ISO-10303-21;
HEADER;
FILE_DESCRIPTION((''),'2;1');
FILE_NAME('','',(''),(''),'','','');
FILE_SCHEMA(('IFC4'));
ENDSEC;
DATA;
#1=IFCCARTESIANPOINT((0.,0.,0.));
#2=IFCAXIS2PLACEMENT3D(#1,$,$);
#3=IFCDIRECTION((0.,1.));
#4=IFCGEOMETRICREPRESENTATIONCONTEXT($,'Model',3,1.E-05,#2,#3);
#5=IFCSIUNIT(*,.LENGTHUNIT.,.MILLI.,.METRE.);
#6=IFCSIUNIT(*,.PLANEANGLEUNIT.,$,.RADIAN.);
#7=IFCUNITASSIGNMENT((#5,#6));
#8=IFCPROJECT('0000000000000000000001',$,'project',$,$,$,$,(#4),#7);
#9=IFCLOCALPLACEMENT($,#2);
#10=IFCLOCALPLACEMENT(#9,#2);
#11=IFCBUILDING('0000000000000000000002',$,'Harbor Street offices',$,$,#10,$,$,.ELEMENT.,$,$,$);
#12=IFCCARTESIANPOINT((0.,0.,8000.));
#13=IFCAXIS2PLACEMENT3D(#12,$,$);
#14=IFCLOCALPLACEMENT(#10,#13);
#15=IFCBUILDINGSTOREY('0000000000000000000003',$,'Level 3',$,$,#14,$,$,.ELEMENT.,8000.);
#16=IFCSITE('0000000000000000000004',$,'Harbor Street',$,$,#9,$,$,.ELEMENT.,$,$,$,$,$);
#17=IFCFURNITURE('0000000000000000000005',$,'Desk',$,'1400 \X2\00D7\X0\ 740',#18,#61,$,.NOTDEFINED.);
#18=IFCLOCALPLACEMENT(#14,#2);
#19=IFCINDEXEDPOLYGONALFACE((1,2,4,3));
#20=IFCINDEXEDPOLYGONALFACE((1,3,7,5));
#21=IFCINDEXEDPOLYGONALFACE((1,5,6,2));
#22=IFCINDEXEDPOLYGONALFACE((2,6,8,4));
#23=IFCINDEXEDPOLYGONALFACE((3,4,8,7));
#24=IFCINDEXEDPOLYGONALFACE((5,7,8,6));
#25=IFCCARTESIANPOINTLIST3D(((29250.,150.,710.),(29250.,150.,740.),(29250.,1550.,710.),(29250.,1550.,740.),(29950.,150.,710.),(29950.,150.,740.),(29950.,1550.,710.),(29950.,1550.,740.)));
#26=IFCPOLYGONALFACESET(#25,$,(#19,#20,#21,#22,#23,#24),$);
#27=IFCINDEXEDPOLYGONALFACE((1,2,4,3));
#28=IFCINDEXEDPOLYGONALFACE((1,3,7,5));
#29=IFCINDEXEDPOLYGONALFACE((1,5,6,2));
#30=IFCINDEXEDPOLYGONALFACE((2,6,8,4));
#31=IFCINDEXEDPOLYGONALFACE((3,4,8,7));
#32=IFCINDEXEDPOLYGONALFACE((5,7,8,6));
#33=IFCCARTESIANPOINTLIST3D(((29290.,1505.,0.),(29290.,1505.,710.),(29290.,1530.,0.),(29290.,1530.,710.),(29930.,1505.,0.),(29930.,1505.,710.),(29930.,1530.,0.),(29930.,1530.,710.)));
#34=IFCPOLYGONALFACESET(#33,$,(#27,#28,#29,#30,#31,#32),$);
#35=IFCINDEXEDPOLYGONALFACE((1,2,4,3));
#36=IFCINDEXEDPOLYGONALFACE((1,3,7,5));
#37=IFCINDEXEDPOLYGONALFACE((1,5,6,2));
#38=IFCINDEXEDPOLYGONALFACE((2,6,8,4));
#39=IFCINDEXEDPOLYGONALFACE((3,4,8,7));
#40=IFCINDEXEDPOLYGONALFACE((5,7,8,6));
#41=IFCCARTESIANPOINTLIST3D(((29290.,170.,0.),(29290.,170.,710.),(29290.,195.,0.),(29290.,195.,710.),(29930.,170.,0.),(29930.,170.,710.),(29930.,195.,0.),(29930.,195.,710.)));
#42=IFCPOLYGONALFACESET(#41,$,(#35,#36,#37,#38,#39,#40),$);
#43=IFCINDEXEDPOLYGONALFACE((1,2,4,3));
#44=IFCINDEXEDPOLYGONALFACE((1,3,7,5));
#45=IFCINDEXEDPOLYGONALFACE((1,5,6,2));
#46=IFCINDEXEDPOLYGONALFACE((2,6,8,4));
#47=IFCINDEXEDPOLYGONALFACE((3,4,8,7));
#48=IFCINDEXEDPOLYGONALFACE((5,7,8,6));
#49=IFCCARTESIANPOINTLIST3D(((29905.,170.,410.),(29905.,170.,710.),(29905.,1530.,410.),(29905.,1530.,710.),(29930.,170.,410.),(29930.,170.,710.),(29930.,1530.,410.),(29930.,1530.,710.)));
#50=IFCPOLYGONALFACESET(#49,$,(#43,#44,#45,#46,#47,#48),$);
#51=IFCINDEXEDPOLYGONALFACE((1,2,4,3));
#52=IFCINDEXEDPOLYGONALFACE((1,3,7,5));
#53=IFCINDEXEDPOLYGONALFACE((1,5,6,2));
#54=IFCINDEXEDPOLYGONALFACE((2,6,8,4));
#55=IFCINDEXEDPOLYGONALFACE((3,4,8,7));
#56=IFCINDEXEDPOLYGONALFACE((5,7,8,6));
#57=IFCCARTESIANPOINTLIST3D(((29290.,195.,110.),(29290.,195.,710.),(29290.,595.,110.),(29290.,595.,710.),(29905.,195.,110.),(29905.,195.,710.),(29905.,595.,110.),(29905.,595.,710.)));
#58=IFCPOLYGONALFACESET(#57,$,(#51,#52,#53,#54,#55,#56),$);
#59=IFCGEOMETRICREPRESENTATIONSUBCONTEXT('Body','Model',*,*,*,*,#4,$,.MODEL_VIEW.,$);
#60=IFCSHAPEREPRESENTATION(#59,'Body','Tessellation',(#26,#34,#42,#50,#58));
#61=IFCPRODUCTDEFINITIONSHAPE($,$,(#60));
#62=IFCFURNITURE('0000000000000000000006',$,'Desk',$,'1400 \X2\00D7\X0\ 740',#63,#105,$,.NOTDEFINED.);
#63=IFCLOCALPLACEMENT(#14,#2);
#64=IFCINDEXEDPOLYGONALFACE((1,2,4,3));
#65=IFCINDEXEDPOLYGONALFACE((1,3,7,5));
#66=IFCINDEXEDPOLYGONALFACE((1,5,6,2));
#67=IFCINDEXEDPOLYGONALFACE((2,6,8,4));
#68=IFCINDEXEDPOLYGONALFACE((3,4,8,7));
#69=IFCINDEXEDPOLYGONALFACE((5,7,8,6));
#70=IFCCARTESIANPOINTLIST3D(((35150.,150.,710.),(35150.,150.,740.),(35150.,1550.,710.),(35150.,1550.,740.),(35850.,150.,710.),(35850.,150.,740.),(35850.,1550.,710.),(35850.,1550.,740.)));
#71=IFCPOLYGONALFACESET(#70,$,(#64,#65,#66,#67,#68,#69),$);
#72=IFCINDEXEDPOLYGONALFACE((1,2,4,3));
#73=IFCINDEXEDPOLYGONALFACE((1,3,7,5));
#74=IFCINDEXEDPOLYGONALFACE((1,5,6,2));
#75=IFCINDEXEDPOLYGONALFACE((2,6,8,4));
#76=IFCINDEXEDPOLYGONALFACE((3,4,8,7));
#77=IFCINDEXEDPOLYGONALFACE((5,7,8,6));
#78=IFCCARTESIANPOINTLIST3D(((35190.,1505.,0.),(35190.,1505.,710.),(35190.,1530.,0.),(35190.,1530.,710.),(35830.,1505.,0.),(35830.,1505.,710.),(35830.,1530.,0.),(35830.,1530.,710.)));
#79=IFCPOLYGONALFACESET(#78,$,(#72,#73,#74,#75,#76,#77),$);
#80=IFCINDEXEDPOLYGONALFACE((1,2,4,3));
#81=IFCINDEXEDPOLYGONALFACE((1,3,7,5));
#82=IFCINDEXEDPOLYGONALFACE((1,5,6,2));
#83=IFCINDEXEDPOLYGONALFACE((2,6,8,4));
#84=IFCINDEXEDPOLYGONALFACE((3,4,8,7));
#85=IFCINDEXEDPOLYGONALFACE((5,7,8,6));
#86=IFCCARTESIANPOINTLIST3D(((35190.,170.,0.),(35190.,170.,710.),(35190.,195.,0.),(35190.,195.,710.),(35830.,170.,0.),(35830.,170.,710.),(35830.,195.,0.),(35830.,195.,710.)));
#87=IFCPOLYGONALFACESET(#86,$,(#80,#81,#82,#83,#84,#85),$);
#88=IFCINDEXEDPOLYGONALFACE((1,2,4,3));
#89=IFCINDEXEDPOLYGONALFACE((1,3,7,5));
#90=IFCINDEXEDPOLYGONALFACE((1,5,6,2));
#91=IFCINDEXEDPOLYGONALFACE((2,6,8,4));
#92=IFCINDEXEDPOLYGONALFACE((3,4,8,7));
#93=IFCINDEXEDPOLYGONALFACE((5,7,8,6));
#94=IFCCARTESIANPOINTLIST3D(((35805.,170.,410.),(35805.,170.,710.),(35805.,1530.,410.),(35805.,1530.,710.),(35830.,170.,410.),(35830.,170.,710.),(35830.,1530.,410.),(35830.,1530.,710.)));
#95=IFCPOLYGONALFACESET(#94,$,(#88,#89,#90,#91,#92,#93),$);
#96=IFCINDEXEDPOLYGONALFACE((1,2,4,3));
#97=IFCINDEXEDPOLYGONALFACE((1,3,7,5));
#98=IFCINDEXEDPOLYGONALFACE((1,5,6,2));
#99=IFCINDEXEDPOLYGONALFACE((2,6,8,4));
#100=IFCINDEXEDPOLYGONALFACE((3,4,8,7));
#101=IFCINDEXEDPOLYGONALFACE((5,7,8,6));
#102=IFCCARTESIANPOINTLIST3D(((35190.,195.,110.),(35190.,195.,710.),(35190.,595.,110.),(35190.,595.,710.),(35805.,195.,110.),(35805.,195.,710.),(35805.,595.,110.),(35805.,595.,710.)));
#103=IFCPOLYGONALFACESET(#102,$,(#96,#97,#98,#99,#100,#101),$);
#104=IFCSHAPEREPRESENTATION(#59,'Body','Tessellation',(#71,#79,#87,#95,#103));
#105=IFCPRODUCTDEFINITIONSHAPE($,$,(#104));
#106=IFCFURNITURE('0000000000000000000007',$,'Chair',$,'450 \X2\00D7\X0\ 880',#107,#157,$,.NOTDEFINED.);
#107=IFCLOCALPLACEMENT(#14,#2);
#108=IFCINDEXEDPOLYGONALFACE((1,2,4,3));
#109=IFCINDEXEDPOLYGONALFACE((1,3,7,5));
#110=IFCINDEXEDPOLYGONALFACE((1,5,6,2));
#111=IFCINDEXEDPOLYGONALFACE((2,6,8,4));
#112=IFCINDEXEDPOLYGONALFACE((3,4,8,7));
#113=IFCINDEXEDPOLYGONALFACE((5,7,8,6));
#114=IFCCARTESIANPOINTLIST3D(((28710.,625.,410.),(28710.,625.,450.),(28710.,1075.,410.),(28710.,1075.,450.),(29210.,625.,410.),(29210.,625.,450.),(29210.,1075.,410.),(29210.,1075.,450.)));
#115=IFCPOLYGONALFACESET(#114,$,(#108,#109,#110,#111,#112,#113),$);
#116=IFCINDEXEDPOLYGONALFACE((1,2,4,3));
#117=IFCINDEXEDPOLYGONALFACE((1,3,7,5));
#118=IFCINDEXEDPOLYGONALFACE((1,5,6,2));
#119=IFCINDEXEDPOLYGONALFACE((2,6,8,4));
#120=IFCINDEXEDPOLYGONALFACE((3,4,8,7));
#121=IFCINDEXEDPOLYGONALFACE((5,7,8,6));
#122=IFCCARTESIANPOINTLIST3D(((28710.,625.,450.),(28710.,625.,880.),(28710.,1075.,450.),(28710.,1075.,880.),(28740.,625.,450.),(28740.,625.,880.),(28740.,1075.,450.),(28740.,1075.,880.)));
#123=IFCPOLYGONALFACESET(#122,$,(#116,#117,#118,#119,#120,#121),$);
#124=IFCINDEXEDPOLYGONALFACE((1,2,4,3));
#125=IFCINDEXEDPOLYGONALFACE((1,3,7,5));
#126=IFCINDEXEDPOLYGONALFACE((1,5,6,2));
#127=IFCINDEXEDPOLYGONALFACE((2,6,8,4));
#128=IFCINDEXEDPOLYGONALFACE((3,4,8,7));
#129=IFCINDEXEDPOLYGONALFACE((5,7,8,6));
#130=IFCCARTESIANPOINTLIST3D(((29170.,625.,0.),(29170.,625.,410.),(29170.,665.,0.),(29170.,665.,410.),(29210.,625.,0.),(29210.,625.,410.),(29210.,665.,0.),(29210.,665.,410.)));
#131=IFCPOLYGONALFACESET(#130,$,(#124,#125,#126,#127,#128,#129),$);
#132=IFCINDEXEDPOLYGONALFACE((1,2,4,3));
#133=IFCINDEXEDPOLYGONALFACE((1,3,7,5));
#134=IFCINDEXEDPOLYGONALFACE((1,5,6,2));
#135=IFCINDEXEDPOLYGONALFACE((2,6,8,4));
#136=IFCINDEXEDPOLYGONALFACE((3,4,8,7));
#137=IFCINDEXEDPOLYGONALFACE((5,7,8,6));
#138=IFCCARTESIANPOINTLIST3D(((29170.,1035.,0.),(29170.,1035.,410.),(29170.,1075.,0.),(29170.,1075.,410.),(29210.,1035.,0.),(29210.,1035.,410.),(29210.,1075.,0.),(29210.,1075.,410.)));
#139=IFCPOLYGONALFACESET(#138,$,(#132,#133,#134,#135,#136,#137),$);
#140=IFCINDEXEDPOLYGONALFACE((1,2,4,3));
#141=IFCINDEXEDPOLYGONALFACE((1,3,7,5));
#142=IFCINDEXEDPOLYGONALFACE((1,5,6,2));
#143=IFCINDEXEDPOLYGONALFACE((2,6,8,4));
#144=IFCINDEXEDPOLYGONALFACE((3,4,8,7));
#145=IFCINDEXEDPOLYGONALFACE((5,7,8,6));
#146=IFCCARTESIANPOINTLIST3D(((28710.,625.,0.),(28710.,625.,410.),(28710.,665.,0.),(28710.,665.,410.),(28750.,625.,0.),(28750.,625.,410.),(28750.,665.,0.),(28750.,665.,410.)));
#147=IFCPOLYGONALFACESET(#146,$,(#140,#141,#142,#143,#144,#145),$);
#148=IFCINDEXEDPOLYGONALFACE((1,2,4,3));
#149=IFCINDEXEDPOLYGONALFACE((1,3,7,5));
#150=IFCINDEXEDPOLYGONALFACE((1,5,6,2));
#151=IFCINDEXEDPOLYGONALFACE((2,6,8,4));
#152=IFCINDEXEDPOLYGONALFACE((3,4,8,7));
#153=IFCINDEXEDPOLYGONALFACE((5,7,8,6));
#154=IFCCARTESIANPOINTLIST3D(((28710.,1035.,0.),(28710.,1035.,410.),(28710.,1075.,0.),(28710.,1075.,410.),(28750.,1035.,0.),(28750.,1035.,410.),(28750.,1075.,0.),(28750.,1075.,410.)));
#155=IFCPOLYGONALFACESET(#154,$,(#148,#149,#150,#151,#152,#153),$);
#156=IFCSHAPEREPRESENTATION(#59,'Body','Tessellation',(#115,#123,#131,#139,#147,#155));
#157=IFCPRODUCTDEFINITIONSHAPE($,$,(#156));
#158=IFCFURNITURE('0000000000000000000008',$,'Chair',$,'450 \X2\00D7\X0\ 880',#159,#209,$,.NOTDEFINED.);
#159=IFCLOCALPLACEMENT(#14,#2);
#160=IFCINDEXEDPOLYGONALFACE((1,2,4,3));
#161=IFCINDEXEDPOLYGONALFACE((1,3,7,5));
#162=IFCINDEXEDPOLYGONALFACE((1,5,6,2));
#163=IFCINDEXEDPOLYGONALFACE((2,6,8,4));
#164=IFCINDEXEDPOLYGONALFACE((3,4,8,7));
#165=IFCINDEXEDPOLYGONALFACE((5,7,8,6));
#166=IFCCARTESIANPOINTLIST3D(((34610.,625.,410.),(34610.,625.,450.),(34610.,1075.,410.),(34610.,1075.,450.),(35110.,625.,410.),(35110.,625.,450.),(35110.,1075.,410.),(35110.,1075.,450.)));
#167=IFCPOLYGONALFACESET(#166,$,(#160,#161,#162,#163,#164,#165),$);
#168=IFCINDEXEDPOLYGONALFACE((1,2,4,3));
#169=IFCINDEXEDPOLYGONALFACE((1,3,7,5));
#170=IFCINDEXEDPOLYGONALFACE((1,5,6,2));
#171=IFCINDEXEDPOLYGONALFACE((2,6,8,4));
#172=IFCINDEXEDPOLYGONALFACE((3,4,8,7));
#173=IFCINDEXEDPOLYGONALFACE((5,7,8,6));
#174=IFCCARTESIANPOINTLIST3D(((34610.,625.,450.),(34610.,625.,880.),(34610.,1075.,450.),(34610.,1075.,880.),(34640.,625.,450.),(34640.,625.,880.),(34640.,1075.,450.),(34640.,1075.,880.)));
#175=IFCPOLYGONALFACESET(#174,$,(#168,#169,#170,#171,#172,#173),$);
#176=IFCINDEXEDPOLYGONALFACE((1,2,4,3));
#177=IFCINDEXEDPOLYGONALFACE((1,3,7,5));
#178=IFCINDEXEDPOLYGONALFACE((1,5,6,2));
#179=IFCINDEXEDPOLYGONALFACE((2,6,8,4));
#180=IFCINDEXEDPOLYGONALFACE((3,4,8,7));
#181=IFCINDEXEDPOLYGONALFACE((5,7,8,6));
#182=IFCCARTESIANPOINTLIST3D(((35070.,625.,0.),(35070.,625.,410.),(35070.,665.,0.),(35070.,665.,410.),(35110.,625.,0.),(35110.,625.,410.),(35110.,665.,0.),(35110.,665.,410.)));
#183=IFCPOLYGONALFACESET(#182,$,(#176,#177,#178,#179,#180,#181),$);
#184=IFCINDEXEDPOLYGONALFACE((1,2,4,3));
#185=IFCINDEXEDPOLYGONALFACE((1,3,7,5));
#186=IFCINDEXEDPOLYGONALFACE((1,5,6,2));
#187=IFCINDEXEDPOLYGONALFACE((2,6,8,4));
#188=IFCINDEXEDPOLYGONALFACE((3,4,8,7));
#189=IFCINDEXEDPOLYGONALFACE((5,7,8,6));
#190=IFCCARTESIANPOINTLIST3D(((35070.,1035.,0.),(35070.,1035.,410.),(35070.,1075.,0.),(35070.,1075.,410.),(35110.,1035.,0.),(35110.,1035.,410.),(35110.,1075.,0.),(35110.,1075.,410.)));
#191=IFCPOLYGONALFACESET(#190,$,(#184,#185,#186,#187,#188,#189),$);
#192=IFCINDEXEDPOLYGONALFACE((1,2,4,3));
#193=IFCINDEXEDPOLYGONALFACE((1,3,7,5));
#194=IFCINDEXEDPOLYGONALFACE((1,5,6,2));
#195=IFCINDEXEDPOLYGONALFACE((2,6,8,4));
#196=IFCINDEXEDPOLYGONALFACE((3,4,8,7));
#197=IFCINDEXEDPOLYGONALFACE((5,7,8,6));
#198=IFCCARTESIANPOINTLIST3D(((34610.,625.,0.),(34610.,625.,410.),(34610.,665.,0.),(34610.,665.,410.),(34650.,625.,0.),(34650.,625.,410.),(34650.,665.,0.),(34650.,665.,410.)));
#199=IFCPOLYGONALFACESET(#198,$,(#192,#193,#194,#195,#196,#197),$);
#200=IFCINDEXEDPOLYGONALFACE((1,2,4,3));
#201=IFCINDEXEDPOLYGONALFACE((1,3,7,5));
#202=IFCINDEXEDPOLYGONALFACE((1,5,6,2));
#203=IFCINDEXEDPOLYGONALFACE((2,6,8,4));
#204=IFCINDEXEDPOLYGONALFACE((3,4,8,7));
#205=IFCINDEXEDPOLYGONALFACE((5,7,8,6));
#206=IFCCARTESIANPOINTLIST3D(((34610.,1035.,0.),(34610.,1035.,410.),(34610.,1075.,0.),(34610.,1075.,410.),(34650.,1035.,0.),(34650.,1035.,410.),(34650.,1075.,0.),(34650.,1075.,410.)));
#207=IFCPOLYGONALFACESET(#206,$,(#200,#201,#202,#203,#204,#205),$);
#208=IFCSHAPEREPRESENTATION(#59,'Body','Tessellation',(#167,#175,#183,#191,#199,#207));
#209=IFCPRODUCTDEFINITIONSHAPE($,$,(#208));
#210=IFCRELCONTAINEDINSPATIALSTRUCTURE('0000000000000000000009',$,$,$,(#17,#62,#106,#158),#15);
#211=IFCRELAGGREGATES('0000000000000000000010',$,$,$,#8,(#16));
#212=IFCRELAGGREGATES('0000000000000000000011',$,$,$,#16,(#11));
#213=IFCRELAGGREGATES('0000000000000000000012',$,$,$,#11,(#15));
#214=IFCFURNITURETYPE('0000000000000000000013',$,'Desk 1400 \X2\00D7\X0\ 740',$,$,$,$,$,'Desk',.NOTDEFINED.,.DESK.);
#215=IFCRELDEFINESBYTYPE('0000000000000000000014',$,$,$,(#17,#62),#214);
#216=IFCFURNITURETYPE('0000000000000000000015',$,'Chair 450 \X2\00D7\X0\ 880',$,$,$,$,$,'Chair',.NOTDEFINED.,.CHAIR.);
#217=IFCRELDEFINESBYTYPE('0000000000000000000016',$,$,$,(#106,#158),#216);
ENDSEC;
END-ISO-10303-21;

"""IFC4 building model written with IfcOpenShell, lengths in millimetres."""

from ifc_helpers import new_model, si_unit, direction, frame, origin, place, context, subcontext, project, spatial, polyline, outline, extrude, source, transform, mapped, type_object, type_shapes, element, save


model = new_model("IFC4")

# Units and contexts
model_context = context("Model", 3, precision=1e-05, world=origin(), true_north=direction((0.0, 1.0)))
body_context = subcontext(model_context, "Body", "Model", "MODEL_VIEW")
ifc_project = project(units=[si_unit("LENGTHUNIT", "METRE", prefix="MILLI"), si_unit("PLANEANGLEUNIT", "RADIAN")], contexts=[model_context])

# Site, building, storey
site_placement = place(None, origin())
site = spatial("IfcSite", under=ifc_project, at=site_placement, Name="Harbor Street", CompositionType="ELEMENT")
building_placement = place(site_placement, origin())
building = spatial("IfcBuilding", under=site, at=building_placement, Name="Harbor Street offices", CompositionType="ELEMENT")
storey_placement = place(building_placement, frame((0.0, 0.0, 8000.0)))
storey = spatial("IfcBuildingStorey", under=building, at=storey_placement, Name="Level 3", CompositionType="ELEMENT", Elevation=8000.0)

# Furniture
furniture_type_1 = type_object("IfcFurnitureType", Name="Desk 1400 × 740", ElementType="Desk", AssemblyPlace="NOTDEFINED", PredefinedType="DESK")
shared_shape_1 = source(origin(), body_context, "Body", "SweptSolid", [
    extrude(outline(polyline([(-700.0, 0.0), (700.0, 0.0), (700.0, 700.0), (-700.0, 700.0), (-700.0, 0.0)])), frame((0.0, 0.0, 710.0)), (0.0, 0.0, 1.0), 30.0),
    extrude(outline(polyline([(-680.0, 40.0), (-655.0, 40.0), (-655.0, 680.0), (-680.0, 680.0), (-680.0, 40.0)])), origin(), (0.0, 0.0, 1.0), 710.0),
    extrude(outline(polyline([(655.0, 40.0), (680.0, 40.0), (680.0, 680.0), (655.0, 680.0), (655.0, 40.0)])), origin(), (0.0, 0.0, 1.0), 710.0),
    extrude(outline(polyline([(-680.0, 655.0), (680.0, 655.0), (680.0, 680.0), (-680.0, 680.0), (-680.0, 655.0)])), frame((0.0, 0.0, 410.0)), (0.0, 0.0, 1.0), 300.0),
    extrude(outline(polyline([(255.0, 40.0), (655.0, 40.0), (655.0, 655.0), (255.0, 655.0), (255.0, 40.0)])), frame((0.0, 0.0, 110.0)), (0.0, 0.0, 1.0), 600.0),
])
type_shapes(furniture_type_1, [shared_shape_1])
for number, where, z_axis, x_axis, name in (
    (1, (29250.0, 850.0, 0.0), (0.0, 0.0, 1.0), (0.0, -1.0, 0.0), "Desk"),
    (2, (35150.0, 850.0, 0.0), (0.0, 0.0, 1.0), (0.0, -1.0, 0.0), "Desk"),
):
    element("IfcFurniture", number, at=place(storey_placement, frame(where, z_axis=z_axis, x_axis=x_axis)), inside=storey, type_object=furniture_type_1, Name=name, ObjectType="1400 × 740", PredefinedType="NOTDEFINED", context=body_context, shape_type="MappedRepresentation", body=[
        mapped(shared_shape_1, transform((0.0, 0.0, 0.0))),
    ])
furniture_type_2 = type_object("IfcFurnitureType", Name="Chair 450 × 880", ElementType="Chair", AssemblyPlace="NOTDEFINED", PredefinedType="CHAIR")
shared_shape_2 = source(origin(), body_context, "Body", "SweptSolid", [
    extrude(outline(polyline([(-225.0, 0.0), (225.0, 0.0), (225.0, 500.0), (-225.0, 500.0), (-225.0, 0.0)])), frame((0.0, 0.0, 410.0)), (0.0, 0.0, 1.0), 40.0),
    extrude(outline(polyline([(-225.0, 470.0), (225.0, 470.0), (225.0, 500.0), (-225.0, 500.0), (-225.0, 470.0)])), frame((0.0, 0.0, 450.0)), (0.0, 0.0, 1.0), 430.0),
    extrude(outline(polyline([(-225.0, 0.0), (-185.0, 0.0), (-185.0, 40.0), (-225.0, 40.0), (-225.0, 0.0)])), origin(), (0.0, 0.0, 1.0), 410.0),
    extrude(outline(polyline([(185.0, 0.0), (225.0, 0.0), (225.0, 40.0), (185.0, 40.0), (185.0, 0.0)])), origin(), (0.0, 0.0, 1.0), 410.0),
    extrude(outline(polyline([(-225.0, 460.0), (-185.0, 460.0), (-185.0, 500.0), (-225.0, 500.0), (-225.0, 460.0)])), origin(), (0.0, 0.0, 1.0), 410.0),
    extrude(outline(polyline([(185.0, 460.0), (225.0, 460.0), (225.0, 500.0), (185.0, 500.0), (185.0, 460.0)])), origin(), (0.0, 0.0, 1.0), 410.0),
])
type_shapes(furniture_type_2, [shared_shape_2])
for number, where, z_axis, x_axis, name in (
    (3, (29210.0, 850.0, 0.0), (0.0, 0.0, 1.0), (0.0, 1.0, 0.0), "Chair"),
    (4, (35110.0, 850.0, 0.0), (0.0, 0.0, 1.0), (0.0, 1.0, 0.0), "Chair"),
):
    element("IfcFurniture", number, at=place(storey_placement, frame(where, z_axis=z_axis, x_axis=x_axis)), inside=storey, type_object=furniture_type_2, Name=name, ObjectType="450 × 880", PredefinedType="NOTDEFINED", context=body_context, shape_type="MappedRepresentation", body=[
        mapped(shared_shape_2, transform((0.0, 0.0, 0.0))),
    ])

save(model, "model.ifc")
